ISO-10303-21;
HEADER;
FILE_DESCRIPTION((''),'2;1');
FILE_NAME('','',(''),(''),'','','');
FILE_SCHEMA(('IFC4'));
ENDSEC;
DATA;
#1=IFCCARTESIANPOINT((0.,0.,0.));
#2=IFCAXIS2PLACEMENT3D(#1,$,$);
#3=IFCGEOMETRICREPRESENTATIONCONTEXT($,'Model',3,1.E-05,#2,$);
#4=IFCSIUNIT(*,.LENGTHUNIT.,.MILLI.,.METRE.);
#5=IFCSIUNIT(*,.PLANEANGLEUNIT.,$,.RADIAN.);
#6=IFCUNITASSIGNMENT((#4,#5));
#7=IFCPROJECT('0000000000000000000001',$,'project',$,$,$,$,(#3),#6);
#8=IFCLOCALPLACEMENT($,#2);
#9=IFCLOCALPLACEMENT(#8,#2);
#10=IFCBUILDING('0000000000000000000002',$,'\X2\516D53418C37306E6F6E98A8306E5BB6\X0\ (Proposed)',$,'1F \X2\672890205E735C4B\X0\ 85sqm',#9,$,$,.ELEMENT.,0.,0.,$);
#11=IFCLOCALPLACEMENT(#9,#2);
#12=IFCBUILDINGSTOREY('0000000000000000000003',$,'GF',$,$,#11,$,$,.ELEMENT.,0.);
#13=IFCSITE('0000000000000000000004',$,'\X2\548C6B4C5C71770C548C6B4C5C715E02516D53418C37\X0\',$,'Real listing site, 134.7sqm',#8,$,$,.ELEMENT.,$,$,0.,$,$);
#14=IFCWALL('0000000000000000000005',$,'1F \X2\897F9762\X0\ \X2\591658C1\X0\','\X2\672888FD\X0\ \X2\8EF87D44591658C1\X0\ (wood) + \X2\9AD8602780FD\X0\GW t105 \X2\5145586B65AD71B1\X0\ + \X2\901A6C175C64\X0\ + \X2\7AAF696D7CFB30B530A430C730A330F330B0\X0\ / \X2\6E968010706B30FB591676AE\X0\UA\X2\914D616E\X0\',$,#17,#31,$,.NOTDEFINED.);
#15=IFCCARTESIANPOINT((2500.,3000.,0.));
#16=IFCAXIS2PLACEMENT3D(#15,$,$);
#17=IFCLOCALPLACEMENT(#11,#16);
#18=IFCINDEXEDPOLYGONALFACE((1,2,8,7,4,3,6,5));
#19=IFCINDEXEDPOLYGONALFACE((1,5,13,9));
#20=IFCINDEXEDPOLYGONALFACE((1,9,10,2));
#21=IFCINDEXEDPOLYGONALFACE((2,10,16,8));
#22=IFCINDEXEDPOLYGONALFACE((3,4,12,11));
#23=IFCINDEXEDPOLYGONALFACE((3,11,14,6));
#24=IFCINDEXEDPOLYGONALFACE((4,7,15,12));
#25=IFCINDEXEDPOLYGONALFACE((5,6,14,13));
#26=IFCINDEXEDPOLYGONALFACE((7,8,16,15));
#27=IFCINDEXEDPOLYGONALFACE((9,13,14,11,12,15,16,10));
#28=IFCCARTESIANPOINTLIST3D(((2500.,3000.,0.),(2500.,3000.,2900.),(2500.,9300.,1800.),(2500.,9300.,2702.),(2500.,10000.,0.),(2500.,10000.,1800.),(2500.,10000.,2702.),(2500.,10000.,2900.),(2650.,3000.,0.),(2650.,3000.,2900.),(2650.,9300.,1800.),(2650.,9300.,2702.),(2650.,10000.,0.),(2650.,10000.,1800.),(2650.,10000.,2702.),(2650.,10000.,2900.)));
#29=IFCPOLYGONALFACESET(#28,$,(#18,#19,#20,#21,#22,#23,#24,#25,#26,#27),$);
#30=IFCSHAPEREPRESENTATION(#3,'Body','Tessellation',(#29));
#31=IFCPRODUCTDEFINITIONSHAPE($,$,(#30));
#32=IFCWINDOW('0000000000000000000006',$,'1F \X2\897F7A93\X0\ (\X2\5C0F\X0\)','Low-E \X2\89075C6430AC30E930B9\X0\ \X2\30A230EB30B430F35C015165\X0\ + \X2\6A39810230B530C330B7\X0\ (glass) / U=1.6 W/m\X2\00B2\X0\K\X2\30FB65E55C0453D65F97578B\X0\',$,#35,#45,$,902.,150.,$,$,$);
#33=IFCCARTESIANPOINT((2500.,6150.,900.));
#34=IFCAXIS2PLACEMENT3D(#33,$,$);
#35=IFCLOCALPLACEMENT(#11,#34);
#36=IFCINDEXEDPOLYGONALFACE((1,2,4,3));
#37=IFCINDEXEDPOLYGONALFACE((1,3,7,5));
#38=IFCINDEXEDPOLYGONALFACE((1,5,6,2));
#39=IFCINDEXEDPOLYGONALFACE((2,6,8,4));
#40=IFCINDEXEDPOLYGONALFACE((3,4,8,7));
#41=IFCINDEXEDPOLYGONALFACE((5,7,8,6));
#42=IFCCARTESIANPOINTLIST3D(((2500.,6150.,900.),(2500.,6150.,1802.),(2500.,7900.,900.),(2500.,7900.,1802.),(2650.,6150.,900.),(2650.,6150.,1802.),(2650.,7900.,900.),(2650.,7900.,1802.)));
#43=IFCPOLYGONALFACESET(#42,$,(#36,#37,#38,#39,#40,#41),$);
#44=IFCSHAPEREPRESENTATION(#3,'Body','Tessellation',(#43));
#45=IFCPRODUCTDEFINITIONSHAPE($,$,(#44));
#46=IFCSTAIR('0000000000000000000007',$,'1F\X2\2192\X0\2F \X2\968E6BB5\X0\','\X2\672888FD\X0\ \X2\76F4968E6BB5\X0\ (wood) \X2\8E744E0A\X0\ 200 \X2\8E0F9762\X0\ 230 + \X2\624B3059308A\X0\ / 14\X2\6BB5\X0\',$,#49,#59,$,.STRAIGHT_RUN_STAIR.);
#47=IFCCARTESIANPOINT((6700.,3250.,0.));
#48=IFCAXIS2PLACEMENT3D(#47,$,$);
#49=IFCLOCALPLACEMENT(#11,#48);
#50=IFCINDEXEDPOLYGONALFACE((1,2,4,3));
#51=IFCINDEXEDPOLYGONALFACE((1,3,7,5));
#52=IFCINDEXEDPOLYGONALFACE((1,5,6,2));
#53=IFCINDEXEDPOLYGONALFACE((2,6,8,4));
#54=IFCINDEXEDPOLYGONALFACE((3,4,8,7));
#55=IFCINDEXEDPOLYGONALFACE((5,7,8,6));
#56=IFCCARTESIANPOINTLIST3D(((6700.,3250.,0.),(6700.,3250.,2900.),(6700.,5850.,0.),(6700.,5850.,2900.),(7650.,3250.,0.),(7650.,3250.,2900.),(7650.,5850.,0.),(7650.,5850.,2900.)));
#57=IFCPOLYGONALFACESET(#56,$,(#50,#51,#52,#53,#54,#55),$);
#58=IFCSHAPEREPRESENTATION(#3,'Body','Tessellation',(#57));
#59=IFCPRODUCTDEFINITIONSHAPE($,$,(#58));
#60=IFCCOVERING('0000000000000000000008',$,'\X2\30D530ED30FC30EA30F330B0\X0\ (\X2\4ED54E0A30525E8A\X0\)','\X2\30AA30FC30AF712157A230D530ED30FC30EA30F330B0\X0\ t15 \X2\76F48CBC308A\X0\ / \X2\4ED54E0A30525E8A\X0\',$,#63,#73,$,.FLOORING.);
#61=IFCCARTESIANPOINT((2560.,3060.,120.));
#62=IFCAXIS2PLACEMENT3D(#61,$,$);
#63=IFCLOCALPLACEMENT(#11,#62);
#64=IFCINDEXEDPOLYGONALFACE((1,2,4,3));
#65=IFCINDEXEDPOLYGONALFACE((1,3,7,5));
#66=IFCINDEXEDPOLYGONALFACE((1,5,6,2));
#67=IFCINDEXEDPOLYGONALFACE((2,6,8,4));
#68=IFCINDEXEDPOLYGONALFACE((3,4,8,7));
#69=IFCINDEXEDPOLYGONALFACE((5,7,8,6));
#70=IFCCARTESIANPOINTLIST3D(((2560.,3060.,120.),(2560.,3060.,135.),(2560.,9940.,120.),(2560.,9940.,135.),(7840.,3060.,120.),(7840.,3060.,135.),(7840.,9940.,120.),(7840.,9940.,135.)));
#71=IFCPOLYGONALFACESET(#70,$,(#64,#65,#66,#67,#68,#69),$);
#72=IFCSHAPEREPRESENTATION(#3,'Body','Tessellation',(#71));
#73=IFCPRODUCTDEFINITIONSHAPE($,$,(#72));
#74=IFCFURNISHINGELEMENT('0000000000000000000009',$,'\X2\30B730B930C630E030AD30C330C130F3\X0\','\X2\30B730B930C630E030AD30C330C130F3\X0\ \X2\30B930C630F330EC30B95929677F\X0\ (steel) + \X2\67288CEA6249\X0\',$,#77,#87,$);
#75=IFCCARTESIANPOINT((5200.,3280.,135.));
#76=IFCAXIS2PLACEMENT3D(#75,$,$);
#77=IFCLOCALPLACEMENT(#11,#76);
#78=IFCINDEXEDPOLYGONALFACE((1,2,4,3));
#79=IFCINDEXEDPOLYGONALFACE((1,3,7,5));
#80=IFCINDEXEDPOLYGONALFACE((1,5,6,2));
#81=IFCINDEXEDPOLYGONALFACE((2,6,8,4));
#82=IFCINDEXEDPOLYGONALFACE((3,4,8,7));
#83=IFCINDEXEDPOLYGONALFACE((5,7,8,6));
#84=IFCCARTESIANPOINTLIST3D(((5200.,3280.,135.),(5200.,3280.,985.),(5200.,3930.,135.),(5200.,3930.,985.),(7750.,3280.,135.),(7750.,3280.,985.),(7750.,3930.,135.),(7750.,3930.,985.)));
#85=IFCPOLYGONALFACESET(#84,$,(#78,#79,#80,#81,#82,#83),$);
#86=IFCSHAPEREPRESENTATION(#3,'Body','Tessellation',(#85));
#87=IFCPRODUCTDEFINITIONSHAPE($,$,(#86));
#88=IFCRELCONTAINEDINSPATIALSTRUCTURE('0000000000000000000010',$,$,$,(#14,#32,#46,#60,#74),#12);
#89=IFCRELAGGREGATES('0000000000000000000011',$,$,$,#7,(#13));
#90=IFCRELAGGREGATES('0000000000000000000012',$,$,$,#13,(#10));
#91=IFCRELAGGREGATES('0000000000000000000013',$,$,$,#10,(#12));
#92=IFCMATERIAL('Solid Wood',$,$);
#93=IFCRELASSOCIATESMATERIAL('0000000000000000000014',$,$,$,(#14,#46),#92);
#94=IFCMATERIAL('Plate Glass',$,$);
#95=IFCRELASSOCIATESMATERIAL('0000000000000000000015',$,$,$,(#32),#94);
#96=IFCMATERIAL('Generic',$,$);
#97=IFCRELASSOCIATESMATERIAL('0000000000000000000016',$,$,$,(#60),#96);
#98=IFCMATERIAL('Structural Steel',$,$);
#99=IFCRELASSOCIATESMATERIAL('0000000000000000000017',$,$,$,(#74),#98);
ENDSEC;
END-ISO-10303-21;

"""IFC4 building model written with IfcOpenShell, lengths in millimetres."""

from ifc_helpers import new_model, si_unit, frame, frame_2d, origin, place, context, project, spatial, rectangle, extrude, material, element, fill, save


model = new_model("IFC4")

# Units and contexts
model_context = context("Model", 3, precision=1e-05, world=origin())
ifc_project = project(units=[si_unit("LENGTHUNIT", "METRE", prefix="MILLI"), si_unit("PLANEANGLEUNIT", "RADIAN")], contexts=[model_context])

# Site, building, storey
site_placement = place(None, origin())
site = spatial("IfcSite", under=ifc_project, at=site_placement, Name="和歌山県和歌山市六十谷", ObjectType="Real listing site, 134.7sqm", CompositionType="ELEMENT", RefElevation=0.0)
building_placement = place(site_placement, origin())
building = spatial("IfcBuilding", under=site, at=building_placement, Name="六十谷の潮風の家 (Proposed)", ObjectType="1F 木造平屋 85sqm", CompositionType="ELEMENT", ElevationOfRefHeight=0.0, ElevationOfTerrain=0.0)
storey_placement = place(building_placement, origin())
storey = spatial("IfcBuildingStorey", under=building, at=storey_placement, Name="GF", CompositionType="ELEMENT", Elevation=0.0)

# Shared definitions
ifc_material_1 = material(Name="Solid Wood")
ifc_material_2 = material(Name="Generic")

# Shared definitions
ifc_material_3 = material(Name="Plate Glass")

# Wall, opening, window
wall_1_placement = place(storey_placement, frame((2500.0, 3000.0, 0.0)))
wall_1 = element("IfcWall", 1, at=wall_1_placement, inside=storey, material=ifc_material_1, Name="1F 西面 外壁", Description="木製 軸組外壁 (wood) + 高性能GW t105 充填断熱 + 通気層 + 窯業系サイディング / 準耐火・外皮UA配慮", PredefinedType="NOTDEFINED", context=model_context, shape_type="SweptSolid", body=[
    extrude(rectangle(XDim=150.0, YDim=7000.0, at=frame_2d((75.0, 3500.0))), frame((2500.0, 3000.0, 0.0)), (0.0, 0.0, 1.0), 2900.0),
])
opening_1_placement = place(storey_placement, frame((2500.0, 6150.0, 900.0)))
opening_1 = element("IfcOpeningElement", 2, at=opening_1_placement, cuts=wall_1, PredefinedType="NOTDEFINED", context=model_context, shape_type="SweptSolid", body=[
    extrude(rectangle(XDim=150.0, YDim=1750.0, at=frame_2d((75.0, 875.0))), frame((2500.0, 6150.0, 900.0)), (0.0, 0.0, 1.0), 902.0),
])
window_1_placement = place(storey_placement, frame((2500.0, 6150.0, 900.0)))
window_1 = element("IfcWindow", 3, at=window_1_placement, inside=storey, material=ifc_material_3, Name="1F 西窓 (小)", Description="Low-E 複層ガラス アルゴン封入 + 樹脂サッシ (glass) / U=1.6 W/m²K・日射取得型", OverallHeight=902.0, OverallWidth=150.0, context=model_context, shape_type="SweptSolid", body=[
    extrude(rectangle(XDim=150.0, YDim=1750.0, at=frame_2d((75.0, 875.0))), frame((2500.0, 6150.0, 900.0)), (0.0, 0.0, 1.0), 902.0),
])
fill(opening_1, window_1)

# Stair
stair_placement = place(storey_placement, frame((6700.0, 3250.0, 0.0)))
element("IfcStair", 4, at=stair_placement, inside=storey, material=ifc_material_1, Name="1F→2F 階段", Description="木製 直階段 (wood) 蹴上 200 踏面 230 + 手すり / 14段", PredefinedType="STRAIGHT_RUN_STAIR", context=model_context, shape_type="SweptSolid", body=[
    extrude(rectangle(XDim=950.0, YDim=2600.0, at=frame_2d((475.0, 1300.0))), frame((6700.0, 3250.0, 0.0)), (0.0, 0.0, 1.0), 2900.0),
])

# Covering
covering_placement = place(storey_placement, frame((2560.0, 3060.0, 120.0)))
element("IfcCovering", 5, at=covering_placement, inside=storey, material=ifc_material_2, Name="フローリング (仕上げ床)", Description="オーク無垢フローリング t15 直貼り / 仕上げ床", PredefinedType="FLOORING", context=model_context, shape_type="SweptSolid", body=[
    extrude(rectangle(XDim=5280.0, YDim=6880.0, at=frame_2d((2640.0, 3440.0))), frame((2560.0, 3060.0, 120.0)), (0.0, 0.0, 1.0), 15.0),
])

# Furnishing element
ifc_material_4 = material(Name="Structural Steel")
furnishing_placement = place(storey_placement, frame((5200.0, 3280.0, 135.0)))
element("IfcFurnishingElement", 6, at=furnishing_placement, inside=storey, material=ifc_material_4, Name="システムキッチン", Description="システムキッチン ステンレス天板 (steel) + 木質扉", context=model_context, shape_type="SweptSolid", body=[
    extrude(rectangle(XDim=2550.0, YDim=650.0, at=frame_2d((1275.0, 325.0))), frame((5200.0, 3280.0, 135.0)), (0.0, 0.0, 1.0), 850.0),
])

save(model, "model.ifc")
